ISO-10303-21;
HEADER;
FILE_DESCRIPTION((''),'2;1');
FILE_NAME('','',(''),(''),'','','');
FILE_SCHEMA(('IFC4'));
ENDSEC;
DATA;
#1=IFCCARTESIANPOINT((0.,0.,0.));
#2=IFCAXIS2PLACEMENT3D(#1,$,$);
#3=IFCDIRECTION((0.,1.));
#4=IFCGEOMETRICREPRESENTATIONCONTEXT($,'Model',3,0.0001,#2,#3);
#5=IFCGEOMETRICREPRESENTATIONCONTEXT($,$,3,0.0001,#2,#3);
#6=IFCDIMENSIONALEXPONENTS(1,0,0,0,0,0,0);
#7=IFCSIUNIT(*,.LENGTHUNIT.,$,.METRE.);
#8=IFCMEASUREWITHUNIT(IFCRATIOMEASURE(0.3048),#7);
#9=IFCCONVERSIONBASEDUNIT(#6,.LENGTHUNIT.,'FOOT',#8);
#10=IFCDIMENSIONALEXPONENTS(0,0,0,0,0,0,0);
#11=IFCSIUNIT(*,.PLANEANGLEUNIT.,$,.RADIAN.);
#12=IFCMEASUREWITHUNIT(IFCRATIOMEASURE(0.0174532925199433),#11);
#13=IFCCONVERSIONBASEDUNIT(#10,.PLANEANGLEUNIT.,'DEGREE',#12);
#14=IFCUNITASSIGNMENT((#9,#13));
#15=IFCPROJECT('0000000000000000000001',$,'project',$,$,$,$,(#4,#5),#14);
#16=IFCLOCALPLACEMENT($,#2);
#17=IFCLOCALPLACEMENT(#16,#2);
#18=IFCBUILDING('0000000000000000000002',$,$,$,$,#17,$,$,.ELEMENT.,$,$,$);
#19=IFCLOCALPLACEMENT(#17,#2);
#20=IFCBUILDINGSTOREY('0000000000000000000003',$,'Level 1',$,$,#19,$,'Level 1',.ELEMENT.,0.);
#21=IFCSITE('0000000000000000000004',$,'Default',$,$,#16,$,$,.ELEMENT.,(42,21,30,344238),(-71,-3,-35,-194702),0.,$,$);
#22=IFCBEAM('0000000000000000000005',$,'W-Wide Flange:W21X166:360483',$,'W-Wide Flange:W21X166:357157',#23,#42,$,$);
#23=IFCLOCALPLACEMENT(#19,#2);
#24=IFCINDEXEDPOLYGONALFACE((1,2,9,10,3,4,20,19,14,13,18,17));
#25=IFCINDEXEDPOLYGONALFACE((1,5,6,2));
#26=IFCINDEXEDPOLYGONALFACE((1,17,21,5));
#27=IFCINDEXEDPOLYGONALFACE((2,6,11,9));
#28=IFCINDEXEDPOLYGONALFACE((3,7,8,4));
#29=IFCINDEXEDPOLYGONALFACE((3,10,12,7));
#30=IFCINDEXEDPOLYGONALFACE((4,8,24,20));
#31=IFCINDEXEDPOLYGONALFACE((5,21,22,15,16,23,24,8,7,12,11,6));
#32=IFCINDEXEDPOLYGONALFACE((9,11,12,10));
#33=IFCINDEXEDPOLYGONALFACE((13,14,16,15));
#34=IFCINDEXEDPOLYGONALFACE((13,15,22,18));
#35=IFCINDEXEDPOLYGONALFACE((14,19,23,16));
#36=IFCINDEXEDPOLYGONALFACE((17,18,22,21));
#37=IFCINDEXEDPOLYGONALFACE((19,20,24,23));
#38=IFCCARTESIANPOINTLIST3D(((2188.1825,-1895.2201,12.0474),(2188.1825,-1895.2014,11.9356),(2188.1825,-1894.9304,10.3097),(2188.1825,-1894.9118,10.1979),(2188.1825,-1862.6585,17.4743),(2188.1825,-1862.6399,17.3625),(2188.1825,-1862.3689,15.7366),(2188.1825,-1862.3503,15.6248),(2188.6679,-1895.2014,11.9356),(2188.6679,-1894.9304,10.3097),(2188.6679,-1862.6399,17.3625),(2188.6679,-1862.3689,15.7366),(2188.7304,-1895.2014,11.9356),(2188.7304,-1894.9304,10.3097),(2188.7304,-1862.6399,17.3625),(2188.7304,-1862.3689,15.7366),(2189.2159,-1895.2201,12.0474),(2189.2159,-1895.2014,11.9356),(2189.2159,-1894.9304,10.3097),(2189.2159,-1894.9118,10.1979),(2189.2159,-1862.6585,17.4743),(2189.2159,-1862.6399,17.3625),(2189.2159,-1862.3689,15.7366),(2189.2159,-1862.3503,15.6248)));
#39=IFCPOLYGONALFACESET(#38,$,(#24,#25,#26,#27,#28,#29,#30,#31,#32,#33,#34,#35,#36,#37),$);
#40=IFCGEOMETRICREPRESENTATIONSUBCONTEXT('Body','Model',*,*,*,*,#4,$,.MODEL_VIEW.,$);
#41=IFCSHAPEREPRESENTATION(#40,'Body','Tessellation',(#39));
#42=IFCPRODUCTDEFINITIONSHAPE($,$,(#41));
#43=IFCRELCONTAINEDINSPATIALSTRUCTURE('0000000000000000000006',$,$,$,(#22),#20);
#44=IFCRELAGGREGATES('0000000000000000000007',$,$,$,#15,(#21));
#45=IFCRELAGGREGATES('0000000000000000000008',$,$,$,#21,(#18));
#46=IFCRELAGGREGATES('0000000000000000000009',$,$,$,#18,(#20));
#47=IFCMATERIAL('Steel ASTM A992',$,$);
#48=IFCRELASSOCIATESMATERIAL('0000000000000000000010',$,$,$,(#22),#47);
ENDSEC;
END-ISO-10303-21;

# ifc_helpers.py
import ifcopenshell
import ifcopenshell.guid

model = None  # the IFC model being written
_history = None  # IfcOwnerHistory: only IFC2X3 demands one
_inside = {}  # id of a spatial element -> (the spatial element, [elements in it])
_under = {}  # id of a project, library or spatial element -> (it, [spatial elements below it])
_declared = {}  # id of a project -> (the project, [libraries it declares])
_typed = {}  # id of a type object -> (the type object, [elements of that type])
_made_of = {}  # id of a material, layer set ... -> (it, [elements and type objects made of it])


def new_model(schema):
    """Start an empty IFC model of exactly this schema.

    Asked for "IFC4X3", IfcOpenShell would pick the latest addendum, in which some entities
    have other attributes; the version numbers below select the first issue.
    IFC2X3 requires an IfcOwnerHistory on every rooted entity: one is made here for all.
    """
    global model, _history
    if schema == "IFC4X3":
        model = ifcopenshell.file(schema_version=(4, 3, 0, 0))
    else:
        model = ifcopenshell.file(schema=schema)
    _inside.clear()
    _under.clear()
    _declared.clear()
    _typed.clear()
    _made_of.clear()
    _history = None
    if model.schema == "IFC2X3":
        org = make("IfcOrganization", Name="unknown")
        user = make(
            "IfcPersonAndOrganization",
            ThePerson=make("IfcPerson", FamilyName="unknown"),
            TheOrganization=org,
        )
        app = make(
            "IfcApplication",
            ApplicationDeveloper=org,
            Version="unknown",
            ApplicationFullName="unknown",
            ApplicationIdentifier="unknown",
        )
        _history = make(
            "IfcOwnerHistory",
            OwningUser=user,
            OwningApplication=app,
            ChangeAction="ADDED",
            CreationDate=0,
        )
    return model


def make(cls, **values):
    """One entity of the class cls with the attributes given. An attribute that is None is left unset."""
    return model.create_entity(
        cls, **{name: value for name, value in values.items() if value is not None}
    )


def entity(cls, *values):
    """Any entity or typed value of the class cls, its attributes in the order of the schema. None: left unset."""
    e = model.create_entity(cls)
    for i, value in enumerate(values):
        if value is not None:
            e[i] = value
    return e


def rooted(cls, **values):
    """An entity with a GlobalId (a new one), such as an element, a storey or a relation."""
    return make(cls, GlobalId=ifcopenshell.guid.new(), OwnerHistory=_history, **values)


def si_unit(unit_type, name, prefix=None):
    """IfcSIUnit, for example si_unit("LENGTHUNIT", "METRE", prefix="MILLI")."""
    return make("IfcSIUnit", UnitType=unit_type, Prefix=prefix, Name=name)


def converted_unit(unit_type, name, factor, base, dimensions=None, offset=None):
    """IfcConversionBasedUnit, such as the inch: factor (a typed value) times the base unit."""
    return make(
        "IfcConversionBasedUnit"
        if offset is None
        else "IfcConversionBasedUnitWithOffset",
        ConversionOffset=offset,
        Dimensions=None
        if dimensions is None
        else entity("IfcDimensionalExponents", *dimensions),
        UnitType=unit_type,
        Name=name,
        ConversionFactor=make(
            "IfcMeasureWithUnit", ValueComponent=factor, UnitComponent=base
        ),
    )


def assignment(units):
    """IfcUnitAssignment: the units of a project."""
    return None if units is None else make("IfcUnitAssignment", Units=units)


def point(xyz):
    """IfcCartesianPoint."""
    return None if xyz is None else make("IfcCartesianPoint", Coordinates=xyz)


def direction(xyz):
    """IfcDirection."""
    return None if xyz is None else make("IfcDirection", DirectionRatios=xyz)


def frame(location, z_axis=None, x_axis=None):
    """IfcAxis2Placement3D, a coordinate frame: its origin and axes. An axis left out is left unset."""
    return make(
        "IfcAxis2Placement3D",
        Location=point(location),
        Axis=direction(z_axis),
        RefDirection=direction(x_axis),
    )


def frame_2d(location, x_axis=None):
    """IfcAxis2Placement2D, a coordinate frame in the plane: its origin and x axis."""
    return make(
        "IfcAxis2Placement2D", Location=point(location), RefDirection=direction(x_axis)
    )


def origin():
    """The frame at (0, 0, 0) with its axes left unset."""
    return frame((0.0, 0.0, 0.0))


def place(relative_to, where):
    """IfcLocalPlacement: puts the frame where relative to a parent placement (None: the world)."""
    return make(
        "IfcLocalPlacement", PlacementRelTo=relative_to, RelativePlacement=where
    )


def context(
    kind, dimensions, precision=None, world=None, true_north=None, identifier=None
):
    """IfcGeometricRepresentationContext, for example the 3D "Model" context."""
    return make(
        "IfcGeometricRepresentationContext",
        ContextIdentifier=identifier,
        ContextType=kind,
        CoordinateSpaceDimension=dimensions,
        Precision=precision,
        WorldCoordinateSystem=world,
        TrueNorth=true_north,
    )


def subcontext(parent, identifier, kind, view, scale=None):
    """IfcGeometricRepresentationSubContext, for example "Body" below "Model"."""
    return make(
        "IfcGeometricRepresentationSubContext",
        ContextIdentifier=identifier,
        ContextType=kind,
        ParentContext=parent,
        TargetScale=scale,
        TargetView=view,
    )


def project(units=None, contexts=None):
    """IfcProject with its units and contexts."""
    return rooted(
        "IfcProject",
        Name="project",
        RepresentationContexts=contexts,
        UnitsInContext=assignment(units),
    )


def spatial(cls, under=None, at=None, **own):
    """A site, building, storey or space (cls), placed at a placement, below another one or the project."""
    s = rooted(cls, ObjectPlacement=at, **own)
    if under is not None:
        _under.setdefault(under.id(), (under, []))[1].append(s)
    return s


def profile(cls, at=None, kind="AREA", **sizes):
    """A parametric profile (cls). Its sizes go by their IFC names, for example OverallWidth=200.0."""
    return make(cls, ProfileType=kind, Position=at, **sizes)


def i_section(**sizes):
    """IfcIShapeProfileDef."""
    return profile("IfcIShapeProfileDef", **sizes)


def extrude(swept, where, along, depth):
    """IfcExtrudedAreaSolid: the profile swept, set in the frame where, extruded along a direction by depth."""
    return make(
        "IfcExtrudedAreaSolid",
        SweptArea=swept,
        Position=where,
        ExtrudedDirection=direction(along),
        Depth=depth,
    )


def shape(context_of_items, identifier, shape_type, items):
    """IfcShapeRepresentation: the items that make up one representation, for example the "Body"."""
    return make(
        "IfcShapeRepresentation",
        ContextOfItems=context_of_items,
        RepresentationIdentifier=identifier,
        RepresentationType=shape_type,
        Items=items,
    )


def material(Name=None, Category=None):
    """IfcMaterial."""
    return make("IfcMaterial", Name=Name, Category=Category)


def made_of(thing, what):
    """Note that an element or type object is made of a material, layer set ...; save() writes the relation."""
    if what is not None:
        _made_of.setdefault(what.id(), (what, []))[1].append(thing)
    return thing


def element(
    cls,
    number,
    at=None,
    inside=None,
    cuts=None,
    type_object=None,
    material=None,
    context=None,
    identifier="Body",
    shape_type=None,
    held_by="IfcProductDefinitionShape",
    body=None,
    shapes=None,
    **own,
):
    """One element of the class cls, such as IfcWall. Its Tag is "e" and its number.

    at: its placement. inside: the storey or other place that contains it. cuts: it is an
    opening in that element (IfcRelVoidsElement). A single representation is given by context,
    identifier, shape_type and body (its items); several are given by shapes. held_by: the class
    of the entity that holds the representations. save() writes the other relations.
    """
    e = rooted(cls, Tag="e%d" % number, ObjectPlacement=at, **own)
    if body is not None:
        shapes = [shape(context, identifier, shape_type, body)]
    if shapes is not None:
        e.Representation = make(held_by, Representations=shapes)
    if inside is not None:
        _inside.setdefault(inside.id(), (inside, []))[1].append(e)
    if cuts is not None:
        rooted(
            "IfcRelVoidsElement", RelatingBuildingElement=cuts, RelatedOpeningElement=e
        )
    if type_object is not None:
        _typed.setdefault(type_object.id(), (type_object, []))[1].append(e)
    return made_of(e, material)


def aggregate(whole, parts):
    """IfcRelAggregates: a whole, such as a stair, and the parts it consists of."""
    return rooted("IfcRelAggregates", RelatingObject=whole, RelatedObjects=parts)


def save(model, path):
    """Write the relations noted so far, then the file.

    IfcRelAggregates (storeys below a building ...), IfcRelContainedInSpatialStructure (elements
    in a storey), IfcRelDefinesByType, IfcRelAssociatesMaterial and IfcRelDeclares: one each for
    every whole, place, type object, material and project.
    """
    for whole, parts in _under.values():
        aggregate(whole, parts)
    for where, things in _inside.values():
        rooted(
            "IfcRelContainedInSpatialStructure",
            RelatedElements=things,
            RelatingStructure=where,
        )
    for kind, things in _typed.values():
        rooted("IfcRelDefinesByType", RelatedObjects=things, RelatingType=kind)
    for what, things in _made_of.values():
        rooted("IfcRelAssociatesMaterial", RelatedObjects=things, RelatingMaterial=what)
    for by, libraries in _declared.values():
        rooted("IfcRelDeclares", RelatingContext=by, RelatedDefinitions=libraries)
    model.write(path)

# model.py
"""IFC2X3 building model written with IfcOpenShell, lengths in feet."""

from ifc_helpers import new_model, entity, si_unit, converted_unit, direction, frame, frame_2d, origin, place, context, subcontext, project, spatial, i_section, extrude, material, element, save


model = new_model("IFC2X3")

# Units and contexts
model_context = context("Model", 3, precision=0.0001, world=origin(), true_north=direction((0.0, 1.0)))
context_of_model = context(None, 3, precision=0.0001, world=origin(), true_north=direction((0.0, 1.0)))
body_context = subcontext(model_context, "Body", "Model", "MODEL_VIEW")
ifc_project = project(units=[converted_unit("LENGTHUNIT", "FOOT", entity("IfcRatioMeasure", 0.3048), si_unit("LENGTHUNIT", "METRE"), dimensions=[1, 0, 0, 0, 0, 0, 0]), converted_unit("PLANEANGLEUNIT", "DEGREE", entity("IfcRatioMeasure", 0.0174532925199433), si_unit("PLANEANGLEUNIT", "RADIAN"), dimensions=[0, 0, 0, 0, 0, 0, 0])], contexts=[model_context, context_of_model])

# Site, building, storey
site_placement = place(None, origin())
site = spatial("IfcSite", under=ifc_project, at=site_placement, Name="Default", CompositionType="ELEMENT", RefLatitude=(42, 21, 30, 344238), RefLongitude=(-71, -3, -35, -194702), RefElevation=0.0)
building_placement = place(site_placement, origin())
building = spatial("IfcBuilding", under=site, at=building_placement, CompositionType="ELEMENT")
storey_placement = place(building_placement, origin())
storey = spatial("IfcBuildingStorey", under=building, at=storey_placement, Name="Level 1", LongName="Level 1", CompositionType="ELEMENT", Elevation=0.0)

# Shared definitions
ifc_material_1 = material(Name="Steel ASTM A992")

# Beam
beam_1_placement = place(storey_placement, frame((2188.6992, -1895.6585, 11.9743), z_axis=(0.0, -0.164399, 0.986394), x_axis=(0.0, 0.986394, 0.164399)))
element("IfcBeam", 1, at=beam_1_placement, inside=storey, material=ifc_material_1, Name="W-Wide Flange:W21X166:360483", ObjectType="W-Wide Flange:W21X166:357157", context=body_context, shape_type="SweptSolid", body=[
    extrude(i_section(OverallWidth=1.0333, OverallDepth=1.875, WebThickness=0.0625, FlangeThickness=0.1133, at=frame_2d((0.0, 0.0), x_axis=(0.0, 1.0))), frame((0.4445, 0.0, -0.9375), z_axis=(1.0, 0.0, 0.0), x_axis=(0.0, 0.0, -1.0)), (0.0, 0.0, 1.0), 33.0107),
])

save(model, "model.ifc")
